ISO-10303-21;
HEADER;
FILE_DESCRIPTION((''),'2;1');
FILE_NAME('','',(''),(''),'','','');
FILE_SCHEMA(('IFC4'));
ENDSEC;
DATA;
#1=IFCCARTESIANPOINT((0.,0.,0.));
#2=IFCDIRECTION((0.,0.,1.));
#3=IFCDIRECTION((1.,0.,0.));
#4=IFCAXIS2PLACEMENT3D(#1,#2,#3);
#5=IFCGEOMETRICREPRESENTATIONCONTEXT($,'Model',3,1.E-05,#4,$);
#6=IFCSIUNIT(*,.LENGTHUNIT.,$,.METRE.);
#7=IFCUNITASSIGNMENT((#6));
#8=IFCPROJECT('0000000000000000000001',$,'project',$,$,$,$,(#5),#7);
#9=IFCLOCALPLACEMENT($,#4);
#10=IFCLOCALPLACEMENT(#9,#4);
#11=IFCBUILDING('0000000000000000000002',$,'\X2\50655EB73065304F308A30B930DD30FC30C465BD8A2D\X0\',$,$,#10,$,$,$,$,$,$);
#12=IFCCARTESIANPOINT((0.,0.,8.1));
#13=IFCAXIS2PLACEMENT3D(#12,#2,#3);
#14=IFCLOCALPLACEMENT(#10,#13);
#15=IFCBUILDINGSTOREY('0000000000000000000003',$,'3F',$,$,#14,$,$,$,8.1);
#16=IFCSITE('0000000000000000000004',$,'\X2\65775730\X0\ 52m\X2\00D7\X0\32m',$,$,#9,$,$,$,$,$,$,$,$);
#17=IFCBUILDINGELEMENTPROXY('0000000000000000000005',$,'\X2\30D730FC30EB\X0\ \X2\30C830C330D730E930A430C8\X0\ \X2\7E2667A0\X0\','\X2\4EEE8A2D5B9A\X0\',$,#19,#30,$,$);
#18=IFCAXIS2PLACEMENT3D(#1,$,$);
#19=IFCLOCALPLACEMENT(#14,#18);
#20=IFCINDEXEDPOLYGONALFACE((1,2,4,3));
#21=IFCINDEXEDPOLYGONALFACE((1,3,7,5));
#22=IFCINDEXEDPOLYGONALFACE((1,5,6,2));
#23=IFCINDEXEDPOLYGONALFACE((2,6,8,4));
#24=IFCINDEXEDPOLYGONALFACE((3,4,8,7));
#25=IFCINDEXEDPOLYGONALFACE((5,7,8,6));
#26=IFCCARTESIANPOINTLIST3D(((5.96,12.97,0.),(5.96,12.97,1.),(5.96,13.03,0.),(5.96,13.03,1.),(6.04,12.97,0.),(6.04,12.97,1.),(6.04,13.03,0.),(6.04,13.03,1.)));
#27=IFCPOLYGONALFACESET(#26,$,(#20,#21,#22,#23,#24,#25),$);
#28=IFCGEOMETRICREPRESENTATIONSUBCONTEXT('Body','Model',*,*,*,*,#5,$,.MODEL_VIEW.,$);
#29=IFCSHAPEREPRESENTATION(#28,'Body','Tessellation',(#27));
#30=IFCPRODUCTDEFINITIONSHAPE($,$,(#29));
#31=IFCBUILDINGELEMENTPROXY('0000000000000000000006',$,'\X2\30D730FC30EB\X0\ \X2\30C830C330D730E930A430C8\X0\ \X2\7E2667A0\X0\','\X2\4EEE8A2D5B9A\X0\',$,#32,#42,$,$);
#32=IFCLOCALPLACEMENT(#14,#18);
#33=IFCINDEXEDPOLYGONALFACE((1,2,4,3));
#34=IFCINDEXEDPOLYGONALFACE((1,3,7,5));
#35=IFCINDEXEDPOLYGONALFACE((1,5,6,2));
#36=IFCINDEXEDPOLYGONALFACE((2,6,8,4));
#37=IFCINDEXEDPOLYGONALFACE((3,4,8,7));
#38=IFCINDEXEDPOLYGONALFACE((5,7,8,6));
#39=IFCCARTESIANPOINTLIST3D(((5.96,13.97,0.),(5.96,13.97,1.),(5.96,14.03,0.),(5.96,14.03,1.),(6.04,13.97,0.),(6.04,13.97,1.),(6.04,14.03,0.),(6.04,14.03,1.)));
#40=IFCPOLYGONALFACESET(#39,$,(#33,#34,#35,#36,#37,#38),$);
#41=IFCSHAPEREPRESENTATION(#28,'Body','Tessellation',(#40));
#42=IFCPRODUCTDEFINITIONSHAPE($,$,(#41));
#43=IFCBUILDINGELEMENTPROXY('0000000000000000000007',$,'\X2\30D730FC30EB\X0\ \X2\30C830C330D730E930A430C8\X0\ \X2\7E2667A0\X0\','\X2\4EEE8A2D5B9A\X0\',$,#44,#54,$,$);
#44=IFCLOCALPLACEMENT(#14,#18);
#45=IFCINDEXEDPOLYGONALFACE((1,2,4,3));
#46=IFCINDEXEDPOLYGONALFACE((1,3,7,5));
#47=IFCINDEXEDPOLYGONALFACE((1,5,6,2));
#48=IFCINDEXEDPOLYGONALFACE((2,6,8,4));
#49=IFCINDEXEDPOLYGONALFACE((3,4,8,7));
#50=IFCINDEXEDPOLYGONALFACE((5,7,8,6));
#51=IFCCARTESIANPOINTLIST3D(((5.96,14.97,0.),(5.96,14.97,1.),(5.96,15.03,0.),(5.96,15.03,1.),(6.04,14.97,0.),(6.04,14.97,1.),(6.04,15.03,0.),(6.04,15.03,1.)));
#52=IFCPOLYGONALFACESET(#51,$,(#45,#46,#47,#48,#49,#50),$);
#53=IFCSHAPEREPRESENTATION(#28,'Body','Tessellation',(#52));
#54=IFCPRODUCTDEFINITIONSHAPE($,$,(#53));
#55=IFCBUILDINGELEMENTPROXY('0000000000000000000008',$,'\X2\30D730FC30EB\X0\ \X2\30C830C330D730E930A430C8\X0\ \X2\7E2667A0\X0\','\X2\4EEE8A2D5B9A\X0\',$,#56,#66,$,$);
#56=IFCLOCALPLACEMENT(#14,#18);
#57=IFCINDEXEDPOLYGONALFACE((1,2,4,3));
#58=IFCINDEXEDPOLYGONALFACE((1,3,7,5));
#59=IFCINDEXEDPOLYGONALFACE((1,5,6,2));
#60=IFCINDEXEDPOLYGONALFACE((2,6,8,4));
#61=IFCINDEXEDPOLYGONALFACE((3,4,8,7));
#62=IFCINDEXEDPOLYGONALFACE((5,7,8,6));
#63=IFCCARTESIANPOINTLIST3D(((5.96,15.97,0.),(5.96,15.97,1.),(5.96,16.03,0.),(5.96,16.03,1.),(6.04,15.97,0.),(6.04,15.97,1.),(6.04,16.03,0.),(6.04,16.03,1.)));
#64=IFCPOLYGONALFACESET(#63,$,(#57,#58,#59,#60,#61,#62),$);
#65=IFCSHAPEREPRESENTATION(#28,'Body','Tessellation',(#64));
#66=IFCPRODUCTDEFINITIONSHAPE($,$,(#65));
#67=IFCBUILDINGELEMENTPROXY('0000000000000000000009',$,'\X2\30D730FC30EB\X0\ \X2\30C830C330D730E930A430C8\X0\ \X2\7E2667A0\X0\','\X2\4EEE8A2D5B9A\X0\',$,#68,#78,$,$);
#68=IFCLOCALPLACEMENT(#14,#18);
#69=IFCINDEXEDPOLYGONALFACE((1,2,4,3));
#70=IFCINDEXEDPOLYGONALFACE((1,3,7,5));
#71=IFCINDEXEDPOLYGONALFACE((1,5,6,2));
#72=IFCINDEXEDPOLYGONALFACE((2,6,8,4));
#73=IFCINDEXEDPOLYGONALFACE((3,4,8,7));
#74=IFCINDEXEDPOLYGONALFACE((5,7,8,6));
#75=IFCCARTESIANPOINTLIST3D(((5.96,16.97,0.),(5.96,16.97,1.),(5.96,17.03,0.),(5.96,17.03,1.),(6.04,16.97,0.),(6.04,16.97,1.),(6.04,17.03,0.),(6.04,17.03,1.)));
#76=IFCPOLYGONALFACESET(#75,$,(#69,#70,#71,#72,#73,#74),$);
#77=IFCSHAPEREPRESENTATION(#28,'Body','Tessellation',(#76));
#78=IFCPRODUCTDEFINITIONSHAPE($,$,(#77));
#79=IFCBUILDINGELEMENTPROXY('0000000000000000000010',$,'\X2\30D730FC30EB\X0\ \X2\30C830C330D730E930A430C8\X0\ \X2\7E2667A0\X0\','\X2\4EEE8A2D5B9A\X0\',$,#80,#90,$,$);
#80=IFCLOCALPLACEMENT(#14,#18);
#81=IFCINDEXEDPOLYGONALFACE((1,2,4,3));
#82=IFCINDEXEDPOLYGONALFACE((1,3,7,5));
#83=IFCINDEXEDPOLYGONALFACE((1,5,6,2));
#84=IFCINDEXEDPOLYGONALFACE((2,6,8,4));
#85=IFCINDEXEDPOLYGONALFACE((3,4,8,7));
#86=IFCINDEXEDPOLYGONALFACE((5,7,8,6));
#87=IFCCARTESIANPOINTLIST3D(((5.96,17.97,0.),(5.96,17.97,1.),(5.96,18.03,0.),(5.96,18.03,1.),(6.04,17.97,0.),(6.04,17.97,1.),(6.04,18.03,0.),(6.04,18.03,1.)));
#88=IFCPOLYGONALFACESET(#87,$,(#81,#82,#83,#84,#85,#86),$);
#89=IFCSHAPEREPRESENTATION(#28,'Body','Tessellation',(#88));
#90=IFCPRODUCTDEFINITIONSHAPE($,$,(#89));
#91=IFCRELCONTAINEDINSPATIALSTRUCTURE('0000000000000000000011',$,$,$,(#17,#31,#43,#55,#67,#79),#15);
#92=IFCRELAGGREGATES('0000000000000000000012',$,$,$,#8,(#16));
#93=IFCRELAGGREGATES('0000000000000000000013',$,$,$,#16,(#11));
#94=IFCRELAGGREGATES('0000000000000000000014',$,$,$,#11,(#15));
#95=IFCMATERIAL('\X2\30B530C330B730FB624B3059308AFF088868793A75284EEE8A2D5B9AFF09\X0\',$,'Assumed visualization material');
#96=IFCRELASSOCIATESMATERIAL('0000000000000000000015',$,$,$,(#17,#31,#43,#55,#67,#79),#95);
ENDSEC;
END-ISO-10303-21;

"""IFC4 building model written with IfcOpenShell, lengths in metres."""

from ifc_helpers import new_model, si_unit, frame, origin_with_axes, place, context, subcontext, project, spatial, rectangle, extrude, material, element, save


model = new_model("IFC4")

# Units and contexts
model_context = context("Model", 3, precision=1e-05, world=origin_with_axes())
body_context = subcontext(model_context, "Body", "Model", "MODEL_VIEW")
ifc_project = project(units=[si_unit("LENGTHUNIT", "METRE")], contexts=[model_context])

# Site, building, storey
site_placement = place(None, origin_with_axes())
site = spatial("IfcSite", under=ifc_project, at=site_placement, Name="敷地 52m×32m")
building_placement = place(site_placement, origin_with_axes())
building = spatial("IfcBuilding", under=site, at=building_placement, Name="健康づくりスポーツ施設")
storey_placement = place(building_placement, frame((0.0, 0.0, 8.1), z_axis=(0.0, 0.0, 1.0), x_axis=(1.0, 0.0, 0.0)))
storey = spatial("IfcBuildingStorey", under=building, at=storey_placement, Name="3F", Elevation=8.1)

# Shared definitions
ifc_material_1 = material(Name="サッシ・手すり（表示用仮設定）", Category="Assumed visualization material")

# Building element proxies
for number, where, z_axis, x_axis, name in (
    (1, (6.0, 13.0, 0.0), (0.0, 0.0, 1.0), (1.0, 0.0, 0.0), "プール トップライト 縦枠"),
    (2, (6.0, 14.0, 0.0), (0.0, 0.0, 1.0), (1.0, 0.0, 0.0), "プール トップライト 縦枠"),
    (3, (6.0, 15.0, 0.0), (0.0, 0.0, 1.0), (1.0, 0.0, 0.0), "プール トップライト 縦枠"),
    (4, (6.0, 16.0, 0.0), (0.0, 0.0, 1.0), (1.0, 0.0, 0.0), "プール トップライト 縦枠"),
    (5, (6.0, 17.0, 0.0), (0.0, 0.0, 1.0), (1.0, 0.0, 0.0), "プール トップライト 縦枠"),
    (6, (6.0, 18.0, 0.0), (0.0, 0.0, 1.0), (1.0, 0.0, 0.0), "プール トップライト 縦枠"),
):
    element("IfcBuildingElementProxy", number, at=place(storey_placement, frame(where, z_axis=z_axis, x_axis=x_axis)), inside=storey, material=ifc_material_1, Name=name, Description="仮設定", context=body_context, shape_type="SweptSolid", body=[
        extrude(rectangle(XDim=0.08, YDim=0.06), origin_with_axes(), (0.0, 0.0, 1.0), 1.0),
    ])

save(model, "model.ifc")
